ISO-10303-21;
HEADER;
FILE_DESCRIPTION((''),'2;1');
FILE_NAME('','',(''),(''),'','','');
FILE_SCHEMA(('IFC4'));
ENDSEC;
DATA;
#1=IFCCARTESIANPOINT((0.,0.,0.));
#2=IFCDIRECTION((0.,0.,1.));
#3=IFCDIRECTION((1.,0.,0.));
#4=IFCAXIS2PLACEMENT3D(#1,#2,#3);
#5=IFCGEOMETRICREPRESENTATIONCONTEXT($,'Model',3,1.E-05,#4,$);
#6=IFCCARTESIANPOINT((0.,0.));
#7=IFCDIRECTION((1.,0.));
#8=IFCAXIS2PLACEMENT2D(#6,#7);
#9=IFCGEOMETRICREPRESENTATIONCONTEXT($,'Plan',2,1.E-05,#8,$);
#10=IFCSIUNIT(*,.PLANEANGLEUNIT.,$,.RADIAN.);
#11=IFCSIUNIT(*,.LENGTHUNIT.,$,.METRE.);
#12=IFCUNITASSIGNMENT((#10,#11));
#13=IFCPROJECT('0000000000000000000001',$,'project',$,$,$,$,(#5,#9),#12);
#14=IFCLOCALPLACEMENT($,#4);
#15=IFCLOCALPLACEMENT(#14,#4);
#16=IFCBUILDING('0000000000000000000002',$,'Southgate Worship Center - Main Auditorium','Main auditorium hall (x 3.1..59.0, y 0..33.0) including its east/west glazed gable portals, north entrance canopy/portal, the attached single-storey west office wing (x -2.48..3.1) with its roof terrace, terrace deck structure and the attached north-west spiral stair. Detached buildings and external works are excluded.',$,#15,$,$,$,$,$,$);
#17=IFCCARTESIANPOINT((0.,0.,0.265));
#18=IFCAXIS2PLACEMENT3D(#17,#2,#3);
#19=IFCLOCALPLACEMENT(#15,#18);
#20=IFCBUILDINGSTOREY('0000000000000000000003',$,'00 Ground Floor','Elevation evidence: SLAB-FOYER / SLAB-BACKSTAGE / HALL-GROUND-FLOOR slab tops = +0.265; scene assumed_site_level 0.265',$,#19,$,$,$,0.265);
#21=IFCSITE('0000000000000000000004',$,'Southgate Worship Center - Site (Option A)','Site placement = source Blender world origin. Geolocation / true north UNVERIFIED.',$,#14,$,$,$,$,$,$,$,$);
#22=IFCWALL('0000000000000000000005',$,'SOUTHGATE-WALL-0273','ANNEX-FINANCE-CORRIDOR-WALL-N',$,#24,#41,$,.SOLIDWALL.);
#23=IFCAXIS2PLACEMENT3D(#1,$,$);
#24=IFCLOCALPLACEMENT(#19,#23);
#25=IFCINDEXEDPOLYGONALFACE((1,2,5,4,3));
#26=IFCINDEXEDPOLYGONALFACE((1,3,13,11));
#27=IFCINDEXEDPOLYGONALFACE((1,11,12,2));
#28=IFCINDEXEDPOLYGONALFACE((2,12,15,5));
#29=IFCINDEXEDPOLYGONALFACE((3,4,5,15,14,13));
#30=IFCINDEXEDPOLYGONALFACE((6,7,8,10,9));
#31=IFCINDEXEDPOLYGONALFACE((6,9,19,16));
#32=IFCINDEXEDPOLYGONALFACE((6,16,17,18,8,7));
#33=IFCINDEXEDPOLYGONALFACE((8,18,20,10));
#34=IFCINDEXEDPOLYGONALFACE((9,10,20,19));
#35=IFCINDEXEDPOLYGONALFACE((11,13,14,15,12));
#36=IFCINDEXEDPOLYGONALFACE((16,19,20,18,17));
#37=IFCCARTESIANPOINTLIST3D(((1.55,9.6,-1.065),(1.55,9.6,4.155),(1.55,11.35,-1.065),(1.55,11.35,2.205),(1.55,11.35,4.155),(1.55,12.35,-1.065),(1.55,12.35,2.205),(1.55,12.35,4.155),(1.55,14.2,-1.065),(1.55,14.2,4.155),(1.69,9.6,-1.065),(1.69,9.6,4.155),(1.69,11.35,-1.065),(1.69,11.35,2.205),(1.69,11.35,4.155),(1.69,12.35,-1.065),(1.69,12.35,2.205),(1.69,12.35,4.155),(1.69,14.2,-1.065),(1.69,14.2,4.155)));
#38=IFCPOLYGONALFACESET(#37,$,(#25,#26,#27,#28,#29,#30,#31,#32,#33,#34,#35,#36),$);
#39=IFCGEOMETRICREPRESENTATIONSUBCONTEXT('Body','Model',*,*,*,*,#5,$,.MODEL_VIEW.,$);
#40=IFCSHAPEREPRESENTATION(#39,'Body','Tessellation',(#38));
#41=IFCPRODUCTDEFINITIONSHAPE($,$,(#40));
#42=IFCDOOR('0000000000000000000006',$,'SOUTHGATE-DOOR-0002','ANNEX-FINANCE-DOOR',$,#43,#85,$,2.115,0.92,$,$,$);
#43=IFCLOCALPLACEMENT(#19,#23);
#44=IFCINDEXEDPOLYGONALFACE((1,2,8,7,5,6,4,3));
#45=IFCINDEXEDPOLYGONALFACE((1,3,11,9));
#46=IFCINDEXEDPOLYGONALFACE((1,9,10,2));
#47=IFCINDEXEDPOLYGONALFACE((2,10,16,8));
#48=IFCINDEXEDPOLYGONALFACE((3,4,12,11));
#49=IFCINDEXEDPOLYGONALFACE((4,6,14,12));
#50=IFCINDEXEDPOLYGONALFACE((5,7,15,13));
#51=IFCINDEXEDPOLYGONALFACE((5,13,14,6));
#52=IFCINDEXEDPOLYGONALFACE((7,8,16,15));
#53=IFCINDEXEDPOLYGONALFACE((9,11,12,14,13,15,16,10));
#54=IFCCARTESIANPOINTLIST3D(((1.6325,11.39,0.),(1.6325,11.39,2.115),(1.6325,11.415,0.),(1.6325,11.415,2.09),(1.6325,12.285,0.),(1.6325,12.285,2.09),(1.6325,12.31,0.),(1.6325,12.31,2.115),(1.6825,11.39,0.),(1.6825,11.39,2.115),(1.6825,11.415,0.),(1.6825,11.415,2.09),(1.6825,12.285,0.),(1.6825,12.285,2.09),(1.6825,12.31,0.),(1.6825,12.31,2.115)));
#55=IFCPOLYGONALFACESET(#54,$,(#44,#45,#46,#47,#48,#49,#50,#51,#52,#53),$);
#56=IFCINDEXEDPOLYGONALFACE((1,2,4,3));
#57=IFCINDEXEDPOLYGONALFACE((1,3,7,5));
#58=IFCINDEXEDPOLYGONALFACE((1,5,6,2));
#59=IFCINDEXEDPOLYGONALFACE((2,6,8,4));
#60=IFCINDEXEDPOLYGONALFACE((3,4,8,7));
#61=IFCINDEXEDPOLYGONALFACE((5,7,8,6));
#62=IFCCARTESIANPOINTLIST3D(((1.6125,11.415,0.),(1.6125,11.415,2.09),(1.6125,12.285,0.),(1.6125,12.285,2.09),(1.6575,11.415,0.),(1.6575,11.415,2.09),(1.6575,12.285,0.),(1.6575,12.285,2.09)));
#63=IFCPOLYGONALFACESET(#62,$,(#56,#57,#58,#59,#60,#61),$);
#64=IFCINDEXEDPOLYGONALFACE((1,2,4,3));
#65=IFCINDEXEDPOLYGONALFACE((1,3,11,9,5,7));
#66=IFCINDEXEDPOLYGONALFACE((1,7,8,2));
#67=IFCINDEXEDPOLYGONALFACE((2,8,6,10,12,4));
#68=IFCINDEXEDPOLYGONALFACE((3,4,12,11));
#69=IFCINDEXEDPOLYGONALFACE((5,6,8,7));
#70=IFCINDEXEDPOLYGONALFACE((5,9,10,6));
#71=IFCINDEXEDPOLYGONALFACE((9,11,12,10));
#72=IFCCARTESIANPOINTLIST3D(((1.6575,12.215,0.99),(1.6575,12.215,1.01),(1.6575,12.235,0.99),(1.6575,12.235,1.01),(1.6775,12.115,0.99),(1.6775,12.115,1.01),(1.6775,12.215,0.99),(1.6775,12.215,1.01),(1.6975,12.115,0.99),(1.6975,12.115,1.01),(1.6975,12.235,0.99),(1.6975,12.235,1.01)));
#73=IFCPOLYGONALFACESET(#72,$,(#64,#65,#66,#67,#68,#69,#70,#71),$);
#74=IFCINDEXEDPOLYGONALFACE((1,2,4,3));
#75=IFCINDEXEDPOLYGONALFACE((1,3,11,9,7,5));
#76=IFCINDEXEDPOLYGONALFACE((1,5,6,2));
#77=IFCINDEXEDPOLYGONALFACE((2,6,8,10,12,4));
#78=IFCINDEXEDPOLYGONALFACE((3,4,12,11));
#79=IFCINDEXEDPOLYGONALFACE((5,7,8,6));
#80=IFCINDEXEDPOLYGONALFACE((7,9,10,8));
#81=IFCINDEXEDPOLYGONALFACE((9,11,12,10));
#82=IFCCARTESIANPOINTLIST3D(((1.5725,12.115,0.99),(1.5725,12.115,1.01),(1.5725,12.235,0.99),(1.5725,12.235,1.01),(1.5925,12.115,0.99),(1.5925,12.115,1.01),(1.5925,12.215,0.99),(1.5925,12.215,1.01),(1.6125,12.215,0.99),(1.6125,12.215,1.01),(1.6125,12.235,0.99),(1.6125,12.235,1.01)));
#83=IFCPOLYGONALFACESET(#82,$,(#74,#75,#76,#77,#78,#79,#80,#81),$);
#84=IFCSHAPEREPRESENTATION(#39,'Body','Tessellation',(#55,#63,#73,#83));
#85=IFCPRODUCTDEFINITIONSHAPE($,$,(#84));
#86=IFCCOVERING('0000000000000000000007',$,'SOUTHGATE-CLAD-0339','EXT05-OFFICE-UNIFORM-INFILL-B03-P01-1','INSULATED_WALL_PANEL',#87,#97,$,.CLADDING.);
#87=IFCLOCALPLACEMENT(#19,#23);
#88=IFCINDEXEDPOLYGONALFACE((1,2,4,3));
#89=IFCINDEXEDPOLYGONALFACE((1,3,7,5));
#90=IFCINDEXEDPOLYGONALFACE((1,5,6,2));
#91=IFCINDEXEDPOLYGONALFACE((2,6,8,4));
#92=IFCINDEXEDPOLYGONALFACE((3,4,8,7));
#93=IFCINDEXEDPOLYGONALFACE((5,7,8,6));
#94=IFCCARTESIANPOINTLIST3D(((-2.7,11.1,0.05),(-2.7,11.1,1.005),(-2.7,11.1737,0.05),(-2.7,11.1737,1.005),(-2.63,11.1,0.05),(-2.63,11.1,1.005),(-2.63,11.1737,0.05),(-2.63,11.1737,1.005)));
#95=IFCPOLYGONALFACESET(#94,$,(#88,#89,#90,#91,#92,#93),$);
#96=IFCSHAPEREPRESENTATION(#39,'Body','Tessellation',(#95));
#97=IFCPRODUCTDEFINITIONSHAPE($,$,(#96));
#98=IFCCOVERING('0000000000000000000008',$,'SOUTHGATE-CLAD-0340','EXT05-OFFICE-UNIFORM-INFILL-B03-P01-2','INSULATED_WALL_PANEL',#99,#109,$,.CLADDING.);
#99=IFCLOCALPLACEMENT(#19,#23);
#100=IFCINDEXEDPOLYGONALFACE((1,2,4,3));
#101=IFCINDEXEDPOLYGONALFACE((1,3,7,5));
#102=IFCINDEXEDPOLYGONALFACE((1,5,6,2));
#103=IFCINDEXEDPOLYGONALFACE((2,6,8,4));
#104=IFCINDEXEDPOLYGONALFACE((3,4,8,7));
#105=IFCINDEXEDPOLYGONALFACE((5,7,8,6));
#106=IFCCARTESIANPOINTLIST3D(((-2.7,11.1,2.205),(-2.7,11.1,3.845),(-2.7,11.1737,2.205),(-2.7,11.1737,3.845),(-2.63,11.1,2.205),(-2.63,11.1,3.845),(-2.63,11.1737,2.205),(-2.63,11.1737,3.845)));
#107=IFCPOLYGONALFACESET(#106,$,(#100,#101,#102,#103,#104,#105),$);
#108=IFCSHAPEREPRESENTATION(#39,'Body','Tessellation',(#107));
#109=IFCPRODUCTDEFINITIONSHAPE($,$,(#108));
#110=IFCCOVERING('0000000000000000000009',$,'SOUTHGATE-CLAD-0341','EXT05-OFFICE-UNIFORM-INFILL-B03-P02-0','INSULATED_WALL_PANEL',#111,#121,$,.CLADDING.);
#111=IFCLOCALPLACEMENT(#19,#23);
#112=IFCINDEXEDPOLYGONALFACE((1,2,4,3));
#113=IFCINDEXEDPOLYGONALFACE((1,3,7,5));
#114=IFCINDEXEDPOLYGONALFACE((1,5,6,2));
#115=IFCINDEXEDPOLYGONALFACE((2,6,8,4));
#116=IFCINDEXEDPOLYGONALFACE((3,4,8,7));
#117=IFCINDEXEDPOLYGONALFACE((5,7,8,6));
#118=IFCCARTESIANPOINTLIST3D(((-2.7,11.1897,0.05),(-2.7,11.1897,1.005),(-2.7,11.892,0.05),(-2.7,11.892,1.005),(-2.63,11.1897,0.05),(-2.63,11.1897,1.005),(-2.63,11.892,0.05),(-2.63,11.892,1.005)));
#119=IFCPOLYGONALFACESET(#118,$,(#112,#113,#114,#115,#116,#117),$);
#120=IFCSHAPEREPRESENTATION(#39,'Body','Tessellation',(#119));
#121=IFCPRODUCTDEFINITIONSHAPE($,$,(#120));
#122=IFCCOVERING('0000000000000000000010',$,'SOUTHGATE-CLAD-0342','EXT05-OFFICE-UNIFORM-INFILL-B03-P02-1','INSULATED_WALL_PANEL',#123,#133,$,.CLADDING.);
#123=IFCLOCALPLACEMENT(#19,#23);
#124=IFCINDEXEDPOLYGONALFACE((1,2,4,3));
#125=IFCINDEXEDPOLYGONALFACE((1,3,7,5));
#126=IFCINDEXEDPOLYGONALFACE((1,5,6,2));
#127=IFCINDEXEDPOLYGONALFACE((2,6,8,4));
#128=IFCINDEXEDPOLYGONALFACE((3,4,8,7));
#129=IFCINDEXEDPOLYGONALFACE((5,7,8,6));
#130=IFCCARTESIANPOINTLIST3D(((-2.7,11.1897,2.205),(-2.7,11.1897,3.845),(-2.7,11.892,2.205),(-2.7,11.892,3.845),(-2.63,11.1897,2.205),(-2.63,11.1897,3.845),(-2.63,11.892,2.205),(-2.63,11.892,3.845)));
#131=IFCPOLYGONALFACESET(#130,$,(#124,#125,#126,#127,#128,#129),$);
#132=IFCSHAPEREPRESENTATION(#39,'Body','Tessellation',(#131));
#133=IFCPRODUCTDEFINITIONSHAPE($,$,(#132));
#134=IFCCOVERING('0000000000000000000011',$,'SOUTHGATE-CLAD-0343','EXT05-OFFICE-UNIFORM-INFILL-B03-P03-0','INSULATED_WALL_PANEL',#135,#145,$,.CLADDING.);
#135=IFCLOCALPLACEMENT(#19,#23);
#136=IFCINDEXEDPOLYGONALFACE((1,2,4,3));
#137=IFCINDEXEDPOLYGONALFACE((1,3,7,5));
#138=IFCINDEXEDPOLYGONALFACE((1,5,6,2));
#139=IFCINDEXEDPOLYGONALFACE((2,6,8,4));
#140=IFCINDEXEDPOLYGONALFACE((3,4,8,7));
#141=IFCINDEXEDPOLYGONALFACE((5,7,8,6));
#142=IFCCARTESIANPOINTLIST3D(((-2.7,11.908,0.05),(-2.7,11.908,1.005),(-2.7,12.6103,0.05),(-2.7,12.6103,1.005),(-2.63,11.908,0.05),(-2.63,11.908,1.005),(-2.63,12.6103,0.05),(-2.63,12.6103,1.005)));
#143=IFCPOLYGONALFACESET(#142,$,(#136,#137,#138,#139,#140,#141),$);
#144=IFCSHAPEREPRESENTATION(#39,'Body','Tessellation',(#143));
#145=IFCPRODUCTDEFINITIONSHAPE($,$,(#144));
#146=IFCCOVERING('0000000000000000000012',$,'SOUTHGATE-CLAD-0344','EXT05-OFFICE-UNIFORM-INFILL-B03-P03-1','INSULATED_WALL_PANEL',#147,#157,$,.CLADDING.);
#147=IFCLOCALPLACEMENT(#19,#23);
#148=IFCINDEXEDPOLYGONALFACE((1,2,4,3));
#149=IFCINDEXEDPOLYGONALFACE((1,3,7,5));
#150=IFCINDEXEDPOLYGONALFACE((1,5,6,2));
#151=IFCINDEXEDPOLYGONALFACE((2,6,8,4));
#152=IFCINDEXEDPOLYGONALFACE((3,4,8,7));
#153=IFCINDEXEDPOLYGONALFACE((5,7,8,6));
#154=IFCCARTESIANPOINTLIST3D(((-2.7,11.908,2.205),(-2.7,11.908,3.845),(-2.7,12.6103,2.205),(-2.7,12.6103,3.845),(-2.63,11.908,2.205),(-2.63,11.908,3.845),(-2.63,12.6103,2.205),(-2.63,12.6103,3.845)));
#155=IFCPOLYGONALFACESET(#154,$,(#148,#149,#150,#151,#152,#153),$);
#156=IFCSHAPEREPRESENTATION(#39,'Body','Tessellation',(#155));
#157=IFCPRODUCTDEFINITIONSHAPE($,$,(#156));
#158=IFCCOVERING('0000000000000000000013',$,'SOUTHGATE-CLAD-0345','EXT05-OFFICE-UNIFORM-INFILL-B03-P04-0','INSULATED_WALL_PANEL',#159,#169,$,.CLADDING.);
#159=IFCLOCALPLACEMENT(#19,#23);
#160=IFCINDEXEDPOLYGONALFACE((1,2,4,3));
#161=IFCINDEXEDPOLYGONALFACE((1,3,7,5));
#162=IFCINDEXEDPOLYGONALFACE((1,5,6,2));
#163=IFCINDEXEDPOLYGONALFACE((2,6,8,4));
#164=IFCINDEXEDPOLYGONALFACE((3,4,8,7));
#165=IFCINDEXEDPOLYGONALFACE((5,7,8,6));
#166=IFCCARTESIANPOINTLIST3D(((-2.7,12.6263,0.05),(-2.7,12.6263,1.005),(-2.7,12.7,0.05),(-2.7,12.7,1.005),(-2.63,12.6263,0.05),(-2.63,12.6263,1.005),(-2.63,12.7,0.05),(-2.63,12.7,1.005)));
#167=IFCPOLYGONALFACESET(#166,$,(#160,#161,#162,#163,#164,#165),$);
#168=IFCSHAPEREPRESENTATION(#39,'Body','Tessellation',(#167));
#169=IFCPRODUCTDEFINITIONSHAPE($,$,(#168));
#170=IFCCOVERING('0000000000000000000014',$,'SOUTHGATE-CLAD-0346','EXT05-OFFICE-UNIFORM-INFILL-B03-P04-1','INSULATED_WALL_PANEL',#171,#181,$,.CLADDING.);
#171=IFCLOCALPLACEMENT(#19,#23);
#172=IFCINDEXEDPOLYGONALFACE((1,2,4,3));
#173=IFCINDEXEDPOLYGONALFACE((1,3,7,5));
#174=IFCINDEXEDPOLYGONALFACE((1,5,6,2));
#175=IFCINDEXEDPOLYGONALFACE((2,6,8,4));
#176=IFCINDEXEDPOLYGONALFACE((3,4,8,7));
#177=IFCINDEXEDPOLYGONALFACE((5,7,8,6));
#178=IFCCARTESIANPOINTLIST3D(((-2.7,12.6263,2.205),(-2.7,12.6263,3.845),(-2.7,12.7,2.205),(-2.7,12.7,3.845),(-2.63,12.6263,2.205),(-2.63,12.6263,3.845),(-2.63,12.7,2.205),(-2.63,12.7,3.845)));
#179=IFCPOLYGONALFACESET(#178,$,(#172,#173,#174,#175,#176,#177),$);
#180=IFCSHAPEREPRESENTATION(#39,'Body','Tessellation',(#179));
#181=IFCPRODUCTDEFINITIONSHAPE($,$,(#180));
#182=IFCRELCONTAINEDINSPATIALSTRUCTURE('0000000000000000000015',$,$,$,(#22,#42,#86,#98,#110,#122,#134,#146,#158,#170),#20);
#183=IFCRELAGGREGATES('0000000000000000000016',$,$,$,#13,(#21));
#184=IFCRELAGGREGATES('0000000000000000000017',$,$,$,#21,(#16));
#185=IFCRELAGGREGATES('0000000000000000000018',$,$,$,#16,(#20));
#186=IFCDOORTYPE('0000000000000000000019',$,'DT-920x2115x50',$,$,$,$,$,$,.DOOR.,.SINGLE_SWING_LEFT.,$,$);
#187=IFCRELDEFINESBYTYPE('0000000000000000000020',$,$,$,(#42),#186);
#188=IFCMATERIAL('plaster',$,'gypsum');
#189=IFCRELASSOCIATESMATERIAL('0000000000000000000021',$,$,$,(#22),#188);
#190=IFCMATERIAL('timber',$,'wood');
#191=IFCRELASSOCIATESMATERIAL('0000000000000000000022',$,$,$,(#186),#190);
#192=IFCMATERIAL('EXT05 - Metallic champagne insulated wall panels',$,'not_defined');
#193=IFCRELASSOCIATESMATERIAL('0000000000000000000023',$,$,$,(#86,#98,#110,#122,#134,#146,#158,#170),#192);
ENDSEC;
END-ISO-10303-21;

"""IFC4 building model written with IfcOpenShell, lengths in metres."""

from ifc_helpers import new_model, si_unit, frame, frame_2d, origin_with_axes, origin_2d, origin_2d_with_axis, place, context, subcontext, project, spatial, line, indexed_curve, rectangle, outline, extrude, source, transform, mapped, material, type_object, type_shapes, element, fill, save


model = new_model("IFC4")

# Units and contexts
model_context = context("Model", 3, precision=1e-05, world=origin_with_axes())
plan_context = context("Plan", 2, precision=1e-05, world=origin_2d_with_axis())
body_context = subcontext(model_context, "Body", "Model", "MODEL_VIEW")
ifc_project = project(units=[si_unit("PLANEANGLEUNIT", "RADIAN"), si_unit("LENGTHUNIT", "METRE")], contexts=[model_context, plan_context])

# Site, building, storey
site_placement = place(None, origin_with_axes())
site = spatial("IfcSite", under=ifc_project, at=site_placement, Name="Southgate Worship Center - Site (Option A)", Description="Site placement = source Blender world origin. Geolocation / true north UNVERIFIED.")
building_placement = place(site_placement, origin_with_axes())
building = spatial("IfcBuilding", under=site, at=building_placement, Name="Southgate Worship Center - Main Auditorium", Description="Main auditorium hall (x 3.1..59.0, y 0..33.0) including its east/west glazed gable portals, north entrance canopy/portal, the attached single-storey west office wing (x -2.48..3.1) with its roof terrace, terrace deck structure and the attached north-west spiral stair. Detached buildings and external works are excluded.")
storey_placement = place(building_placement, frame((0.0, 0.0, 0.265), z_axis=(0.0, 0.0, 1.0), x_axis=(1.0, 0.0, 0.0)))
storey = spatial("IfcBuildingStorey", under=building, at=storey_placement, Name="00 Ground Floor", Description="Elevation evidence: SLAB-FOYER / SLAB-BACKSTAGE / HALL-GROUND-FLOOR slab tops = +0.265; scene assumed_site_level 0.265", Elevation=0.265)

# Shared definitions
ifc_material_1 = material(Name="plaster", Category="gypsum")

# Wall, opening, door
wall_1_placement = place(storey_placement, frame((1.69, 9.6, -1.065), z_axis=(0.0, 0.0, 1.0), x_axis=(0.0, 1.0, 0.0)))
wall_1 = element("IfcWall", 1, at=wall_1_placement, inside=storey, material=ifc_material_1, Name="SOUTHGATE-WALL-0273", Description="ANNEX-FINANCE-CORRIDOR-WALL-N", PredefinedType="SOLIDWALL", context=body_context, shape_type="SweptSolid", body=[
    extrude(outline(indexed_curve([(0.0, 0.0), (4.6, 0.0), (4.6, 5.22), (2.75, 5.22), (2.75, 3.27), (1.75, 3.27), (1.75, 5.22), (0.0, 5.22), (0.0, 0.0)], self_intersect=False)), frame((0.0, 0.0, 0.0), z_axis=(0.0, -1.0, 0.0), x_axis=(1.0, 0.0, 0.0)), (0.0, 0.0, -1.0), 0.14),
])
opening_1_placement = place(wall_1_placement, origin_with_axes())
opening_1 = element("IfcOpeningElement", 2, at=opening_1_placement, cuts=wall_1, PredefinedType="OPENING", context=body_context, shape_type="SweptSolid", body=[
    extrude(rectangle(XDim=1.0, YDim=0.24, at=frame_2d((2.25, 0.07))), origin_with_axes(), (0.0, 0.0, 1.0), 3.27),
])
ifc_material_2 = material(Name="timber", Category="wood")
door_type = type_object("IfcDoorType", Name="DT-920x2115x50", OperationType="SINGLE_SWING_LEFT", PredefinedType="DOOR", material=ifc_material_2)
shared_shape_1 = source(origin_with_axes(), body_context, "Body", "SweptSolid", [
    extrude(outline(indexed_curve([(0.0, 0.0), (0.0, 2.115), (0.92, 2.115), (0.92, 0.0), (0.895, 0.0), (0.895, 2.09), (0.025, 2.09), (0.025, 0.0)], segments=[line(1, 2, 3, 4, 5, 6, 7, 8, 1)])), frame((0.0, 0.0, 0.0), z_axis=(0.0, -1.0, 0.0), x_axis=(1.0, 0.0, 0.0)), (0.0, 0.0, -1.0), 0.05),
    extrude(outline(indexed_curve([(0.0, 0.0), (0.87, 0.0), (0.87, 0.045), (0.0, 0.045)], segments=[line(1, 2, 3, 4, 1)])), frame((0.025, 0.025, 0.0), z_axis=(0.0, 0.0, 1.0), x_axis=(1.0, 0.0, 0.0)), (0.0, 0.0, 1.0), 2.09),
    extrude(outline(indexed_curve([(0.0, 0.0), (0.0, -0.04), (-0.12, -0.04), (-0.12, -0.02), (-0.02, -0.02), (-0.02, 0.0)], segments=[line(1, 2, 3, 4, 5, 6, 1)])), frame((0.845, 0.025, 0.99), z_axis=(0.0, 0.0, 1.0), x_axis=(1.0, 0.0, 0.0)), (0.0, 0.0, 1.0), 0.02),
    extrude(outline(indexed_curve([(0.0, 0.0), (0.0, 0.04), (-0.12, 0.04), (-0.12, 0.02), (-0.02, 0.02), (-0.02, 0.0)], segments=[line(1, 2, 3, 4, 5, 6, 1)])), frame((0.845, 0.07, 0.99), z_axis=(0.0, 0.0, 1.0), x_axis=(1.0, 0.0, 0.0)), (0.0, 0.0, 1.0), 0.02),
])
type_shapes(door_type, [shared_shape_1])
door_placement = place(storey_placement, frame((1.6825, 11.39, 0.0), z_axis=(0.0, 0.0, 1.0), x_axis=(0.0, 1.0, 0.0)))
door = element("IfcDoor", 3, at=door_placement, inside=storey, type_object=door_type, Name="SOUTHGATE-DOOR-0002", Description="ANNEX-FINANCE-DOOR", OverallHeight=2.115, OverallWidth=0.92, context=body_context, shape_type="MappedRepresentation", body=[
    mapped(shared_shape_1, transform((0.0, 0.0, 0.0), x_axis=(1.0, 0.0, 0.0), y_axis=(0.0, 1.0, 0.0), z_axis=(0.0, 0.0, 1.0), scale=1.0)),
])
fill(opening_1, door)

# Coverings
ifc_material_3 = material(Name="EXT05 - Metallic champagne insulated wall panels", Category="not_defined")
covering_1_placement = place(storey_placement, frame((-2.7, 11.1, 0.05), z_axis=(0.0, 0.0, 1.0), x_axis=(1.0, 0.0, 0.0)))
element("IfcCovering", 4, at=covering_1_placement, inside=storey, material=ifc_material_3, Name="SOUTHGATE-CLAD-0339", Description="EXT05-OFFICE-UNIFORM-INFILL-B03-P01-1", ObjectType="INSULATED_WALL_PANEL", PredefinedType="CLADDING", context=body_context, shape_type="SweptSolid", body=[
    extrude(rectangle(XDim=0.0737, YDim=0.07, at=origin_2d()), frame((0.035, 0.0368, 0.0), z_axis=(0.0, 0.0, 1.0), x_axis=(0.0, 1.0, 0.0)), (0.0, 0.0, 1.0), 0.955),
])
covering_2_placement = place(storey_placement, frame((-2.7, 11.1, 2.205), z_axis=(0.0, 0.0, 1.0), x_axis=(1.0, 0.0, 0.0)))
element("IfcCovering", 5, at=covering_2_placement, inside=storey, material=ifc_material_3, Name="SOUTHGATE-CLAD-0340", Description="EXT05-OFFICE-UNIFORM-INFILL-B03-P01-2", ObjectType="INSULATED_WALL_PANEL", PredefinedType="CLADDING", context=body_context, shape_type="SweptSolid", body=[
    extrude(rectangle(XDim=0.0737, YDim=0.07, at=origin_2d()), frame((0.035, 0.0368, 0.0), z_axis=(0.0, 0.0, 1.0), x_axis=(0.0, 1.0, 0.0)), (0.0, 0.0, 1.0), 1.64),
])
covering_3_placement = place(storey_placement, frame((-2.7, 11.1897, 0.05), z_axis=(0.0, 0.0, 1.0), x_axis=(1.0, 0.0, 0.0)))
element("IfcCovering", 6, at=covering_3_placement, inside=storey, material=ifc_material_3, Name="SOUTHGATE-CLAD-0341", Description="EXT05-OFFICE-UNIFORM-INFILL-B03-P02-0", ObjectType="INSULATED_WALL_PANEL", PredefinedType="CLADDING", context=body_context, shape_type="SweptSolid", body=[
    extrude(rectangle(XDim=0.7023, YDim=0.07, at=origin_2d()), frame((0.035, 0.3511, 0.0), z_axis=(0.0, 0.0, 1.0), x_axis=(0.0, 1.0, 0.0)), (0.0, 0.0, 1.0), 0.955),
])
covering_4_placement = place(storey_placement, frame((-2.7, 11.1897, 2.205), z_axis=(0.0, 0.0, 1.0), x_axis=(1.0, 0.0, 0.0)))
element("IfcCovering", 7, at=covering_4_placement, inside=storey, material=ifc_material_3, Name="SOUTHGATE-CLAD-0342", Description="EXT05-OFFICE-UNIFORM-INFILL-B03-P02-1", ObjectType="INSULATED_WALL_PANEL", PredefinedType="CLADDING", context=body_context, shape_type="SweptSolid", body=[
    extrude(rectangle(XDim=0.7023, YDim=0.07, at=origin_2d()), frame((0.035, 0.3511, 0.0), z_axis=(0.0, 0.0, 1.0), x_axis=(0.0, 1.0, 0.0)), (0.0, 0.0, 1.0), 1.64),
])
covering_5_placement = place(storey_placement, frame((-2.7, 11.908, 0.05), z_axis=(0.0, 0.0, 1.0), x_axis=(1.0, 0.0, 0.0)))
element("IfcCovering", 8, at=covering_5_placement, inside=storey, material=ifc_material_3, Name="SOUTHGATE-CLAD-0343", Description="EXT05-OFFICE-UNIFORM-INFILL-B03-P03-0", ObjectType="INSULATED_WALL_PANEL", PredefinedType="CLADDING", context=body_context, shape_type="SweptSolid", body=[
    extrude(rectangle(XDim=0.7023, YDim=0.07, at=origin_2d()), frame((0.035, 0.3512, 0.0), z_axis=(0.0, 0.0, 1.0), x_axis=(0.0, 1.0, 0.0)), (0.0, 0.0, 1.0), 0.955),
])
covering_6_placement = place(storey_placement, frame((-2.7, 11.908, 2.205), z_axis=(0.0, 0.0, 1.0), x_axis=(1.0, 0.0, 0.0)))
element("IfcCovering", 9, at=covering_6_placement, inside=storey, material=ifc_material_3, Name="SOUTHGATE-CLAD-0344", Description="EXT05-OFFICE-UNIFORM-INFILL-B03-P03-1", ObjectType="INSULATED_WALL_PANEL", PredefinedType="CLADDING", context=body_context, shape_type="SweptSolid", body=[
    extrude(rectangle(XDim=0.7023, YDim=0.07, at=origin_2d()), frame((0.035, 0.3512, 0.0), z_axis=(0.0, 0.0, 1.0), x_axis=(0.0, 1.0, 0.0)), (0.0, 0.0, 1.0), 1.64),
])
covering_7_placement = place(storey_placement, frame((-2.7, 12.6263, 0.05), z_axis=(0.0, 0.0, 1.0), x_axis=(1.0, 0.0, 0.0)))
element("IfcCovering", 10, at=covering_7_placement, inside=storey, material=ifc_material_3, Name="SOUTHGATE-CLAD-0345", Description="EXT05-OFFICE-UNIFORM-INFILL-B03-P04-0", ObjectType="INSULATED_WALL_PANEL", PredefinedType="CLADDING", context=body_context, shape_type="SweptSolid", body=[
    extrude(rectangle(XDim=0.0737, YDim=0.07, at=origin_2d()), frame((0.035, 0.0369, 0.0), z_axis=(0.0, 0.0, 1.0), x_axis=(0.0, 1.0, 0.0)), (0.0, 0.0, 1.0), 0.955),
])
covering_8_placement = place(storey_placement, frame((-2.7, 12.6263, 2.205), z_axis=(0.0, 0.0, 1.0), x_axis=(1.0, 0.0, 0.0)))
element("IfcCovering", 11, at=covering_8_placement, inside=storey, material=ifc_material_3, Name="SOUTHGATE-CLAD-0346", Description="EXT05-OFFICE-UNIFORM-INFILL-B03-P04-1", ObjectType="INSULATED_WALL_PANEL", PredefinedType="CLADDING", context=body_context, shape_type="SweptSolid", body=[
    extrude(rectangle(XDim=0.0737, YDim=0.07, at=origin_2d()), frame((0.035, 0.0369, 0.0), z_axis=(0.0, 0.0, 1.0), x_axis=(0.0, 1.0, 0.0)), (0.0, 0.0, 1.0), 1.64),
])

save(model, "model.ifc")
